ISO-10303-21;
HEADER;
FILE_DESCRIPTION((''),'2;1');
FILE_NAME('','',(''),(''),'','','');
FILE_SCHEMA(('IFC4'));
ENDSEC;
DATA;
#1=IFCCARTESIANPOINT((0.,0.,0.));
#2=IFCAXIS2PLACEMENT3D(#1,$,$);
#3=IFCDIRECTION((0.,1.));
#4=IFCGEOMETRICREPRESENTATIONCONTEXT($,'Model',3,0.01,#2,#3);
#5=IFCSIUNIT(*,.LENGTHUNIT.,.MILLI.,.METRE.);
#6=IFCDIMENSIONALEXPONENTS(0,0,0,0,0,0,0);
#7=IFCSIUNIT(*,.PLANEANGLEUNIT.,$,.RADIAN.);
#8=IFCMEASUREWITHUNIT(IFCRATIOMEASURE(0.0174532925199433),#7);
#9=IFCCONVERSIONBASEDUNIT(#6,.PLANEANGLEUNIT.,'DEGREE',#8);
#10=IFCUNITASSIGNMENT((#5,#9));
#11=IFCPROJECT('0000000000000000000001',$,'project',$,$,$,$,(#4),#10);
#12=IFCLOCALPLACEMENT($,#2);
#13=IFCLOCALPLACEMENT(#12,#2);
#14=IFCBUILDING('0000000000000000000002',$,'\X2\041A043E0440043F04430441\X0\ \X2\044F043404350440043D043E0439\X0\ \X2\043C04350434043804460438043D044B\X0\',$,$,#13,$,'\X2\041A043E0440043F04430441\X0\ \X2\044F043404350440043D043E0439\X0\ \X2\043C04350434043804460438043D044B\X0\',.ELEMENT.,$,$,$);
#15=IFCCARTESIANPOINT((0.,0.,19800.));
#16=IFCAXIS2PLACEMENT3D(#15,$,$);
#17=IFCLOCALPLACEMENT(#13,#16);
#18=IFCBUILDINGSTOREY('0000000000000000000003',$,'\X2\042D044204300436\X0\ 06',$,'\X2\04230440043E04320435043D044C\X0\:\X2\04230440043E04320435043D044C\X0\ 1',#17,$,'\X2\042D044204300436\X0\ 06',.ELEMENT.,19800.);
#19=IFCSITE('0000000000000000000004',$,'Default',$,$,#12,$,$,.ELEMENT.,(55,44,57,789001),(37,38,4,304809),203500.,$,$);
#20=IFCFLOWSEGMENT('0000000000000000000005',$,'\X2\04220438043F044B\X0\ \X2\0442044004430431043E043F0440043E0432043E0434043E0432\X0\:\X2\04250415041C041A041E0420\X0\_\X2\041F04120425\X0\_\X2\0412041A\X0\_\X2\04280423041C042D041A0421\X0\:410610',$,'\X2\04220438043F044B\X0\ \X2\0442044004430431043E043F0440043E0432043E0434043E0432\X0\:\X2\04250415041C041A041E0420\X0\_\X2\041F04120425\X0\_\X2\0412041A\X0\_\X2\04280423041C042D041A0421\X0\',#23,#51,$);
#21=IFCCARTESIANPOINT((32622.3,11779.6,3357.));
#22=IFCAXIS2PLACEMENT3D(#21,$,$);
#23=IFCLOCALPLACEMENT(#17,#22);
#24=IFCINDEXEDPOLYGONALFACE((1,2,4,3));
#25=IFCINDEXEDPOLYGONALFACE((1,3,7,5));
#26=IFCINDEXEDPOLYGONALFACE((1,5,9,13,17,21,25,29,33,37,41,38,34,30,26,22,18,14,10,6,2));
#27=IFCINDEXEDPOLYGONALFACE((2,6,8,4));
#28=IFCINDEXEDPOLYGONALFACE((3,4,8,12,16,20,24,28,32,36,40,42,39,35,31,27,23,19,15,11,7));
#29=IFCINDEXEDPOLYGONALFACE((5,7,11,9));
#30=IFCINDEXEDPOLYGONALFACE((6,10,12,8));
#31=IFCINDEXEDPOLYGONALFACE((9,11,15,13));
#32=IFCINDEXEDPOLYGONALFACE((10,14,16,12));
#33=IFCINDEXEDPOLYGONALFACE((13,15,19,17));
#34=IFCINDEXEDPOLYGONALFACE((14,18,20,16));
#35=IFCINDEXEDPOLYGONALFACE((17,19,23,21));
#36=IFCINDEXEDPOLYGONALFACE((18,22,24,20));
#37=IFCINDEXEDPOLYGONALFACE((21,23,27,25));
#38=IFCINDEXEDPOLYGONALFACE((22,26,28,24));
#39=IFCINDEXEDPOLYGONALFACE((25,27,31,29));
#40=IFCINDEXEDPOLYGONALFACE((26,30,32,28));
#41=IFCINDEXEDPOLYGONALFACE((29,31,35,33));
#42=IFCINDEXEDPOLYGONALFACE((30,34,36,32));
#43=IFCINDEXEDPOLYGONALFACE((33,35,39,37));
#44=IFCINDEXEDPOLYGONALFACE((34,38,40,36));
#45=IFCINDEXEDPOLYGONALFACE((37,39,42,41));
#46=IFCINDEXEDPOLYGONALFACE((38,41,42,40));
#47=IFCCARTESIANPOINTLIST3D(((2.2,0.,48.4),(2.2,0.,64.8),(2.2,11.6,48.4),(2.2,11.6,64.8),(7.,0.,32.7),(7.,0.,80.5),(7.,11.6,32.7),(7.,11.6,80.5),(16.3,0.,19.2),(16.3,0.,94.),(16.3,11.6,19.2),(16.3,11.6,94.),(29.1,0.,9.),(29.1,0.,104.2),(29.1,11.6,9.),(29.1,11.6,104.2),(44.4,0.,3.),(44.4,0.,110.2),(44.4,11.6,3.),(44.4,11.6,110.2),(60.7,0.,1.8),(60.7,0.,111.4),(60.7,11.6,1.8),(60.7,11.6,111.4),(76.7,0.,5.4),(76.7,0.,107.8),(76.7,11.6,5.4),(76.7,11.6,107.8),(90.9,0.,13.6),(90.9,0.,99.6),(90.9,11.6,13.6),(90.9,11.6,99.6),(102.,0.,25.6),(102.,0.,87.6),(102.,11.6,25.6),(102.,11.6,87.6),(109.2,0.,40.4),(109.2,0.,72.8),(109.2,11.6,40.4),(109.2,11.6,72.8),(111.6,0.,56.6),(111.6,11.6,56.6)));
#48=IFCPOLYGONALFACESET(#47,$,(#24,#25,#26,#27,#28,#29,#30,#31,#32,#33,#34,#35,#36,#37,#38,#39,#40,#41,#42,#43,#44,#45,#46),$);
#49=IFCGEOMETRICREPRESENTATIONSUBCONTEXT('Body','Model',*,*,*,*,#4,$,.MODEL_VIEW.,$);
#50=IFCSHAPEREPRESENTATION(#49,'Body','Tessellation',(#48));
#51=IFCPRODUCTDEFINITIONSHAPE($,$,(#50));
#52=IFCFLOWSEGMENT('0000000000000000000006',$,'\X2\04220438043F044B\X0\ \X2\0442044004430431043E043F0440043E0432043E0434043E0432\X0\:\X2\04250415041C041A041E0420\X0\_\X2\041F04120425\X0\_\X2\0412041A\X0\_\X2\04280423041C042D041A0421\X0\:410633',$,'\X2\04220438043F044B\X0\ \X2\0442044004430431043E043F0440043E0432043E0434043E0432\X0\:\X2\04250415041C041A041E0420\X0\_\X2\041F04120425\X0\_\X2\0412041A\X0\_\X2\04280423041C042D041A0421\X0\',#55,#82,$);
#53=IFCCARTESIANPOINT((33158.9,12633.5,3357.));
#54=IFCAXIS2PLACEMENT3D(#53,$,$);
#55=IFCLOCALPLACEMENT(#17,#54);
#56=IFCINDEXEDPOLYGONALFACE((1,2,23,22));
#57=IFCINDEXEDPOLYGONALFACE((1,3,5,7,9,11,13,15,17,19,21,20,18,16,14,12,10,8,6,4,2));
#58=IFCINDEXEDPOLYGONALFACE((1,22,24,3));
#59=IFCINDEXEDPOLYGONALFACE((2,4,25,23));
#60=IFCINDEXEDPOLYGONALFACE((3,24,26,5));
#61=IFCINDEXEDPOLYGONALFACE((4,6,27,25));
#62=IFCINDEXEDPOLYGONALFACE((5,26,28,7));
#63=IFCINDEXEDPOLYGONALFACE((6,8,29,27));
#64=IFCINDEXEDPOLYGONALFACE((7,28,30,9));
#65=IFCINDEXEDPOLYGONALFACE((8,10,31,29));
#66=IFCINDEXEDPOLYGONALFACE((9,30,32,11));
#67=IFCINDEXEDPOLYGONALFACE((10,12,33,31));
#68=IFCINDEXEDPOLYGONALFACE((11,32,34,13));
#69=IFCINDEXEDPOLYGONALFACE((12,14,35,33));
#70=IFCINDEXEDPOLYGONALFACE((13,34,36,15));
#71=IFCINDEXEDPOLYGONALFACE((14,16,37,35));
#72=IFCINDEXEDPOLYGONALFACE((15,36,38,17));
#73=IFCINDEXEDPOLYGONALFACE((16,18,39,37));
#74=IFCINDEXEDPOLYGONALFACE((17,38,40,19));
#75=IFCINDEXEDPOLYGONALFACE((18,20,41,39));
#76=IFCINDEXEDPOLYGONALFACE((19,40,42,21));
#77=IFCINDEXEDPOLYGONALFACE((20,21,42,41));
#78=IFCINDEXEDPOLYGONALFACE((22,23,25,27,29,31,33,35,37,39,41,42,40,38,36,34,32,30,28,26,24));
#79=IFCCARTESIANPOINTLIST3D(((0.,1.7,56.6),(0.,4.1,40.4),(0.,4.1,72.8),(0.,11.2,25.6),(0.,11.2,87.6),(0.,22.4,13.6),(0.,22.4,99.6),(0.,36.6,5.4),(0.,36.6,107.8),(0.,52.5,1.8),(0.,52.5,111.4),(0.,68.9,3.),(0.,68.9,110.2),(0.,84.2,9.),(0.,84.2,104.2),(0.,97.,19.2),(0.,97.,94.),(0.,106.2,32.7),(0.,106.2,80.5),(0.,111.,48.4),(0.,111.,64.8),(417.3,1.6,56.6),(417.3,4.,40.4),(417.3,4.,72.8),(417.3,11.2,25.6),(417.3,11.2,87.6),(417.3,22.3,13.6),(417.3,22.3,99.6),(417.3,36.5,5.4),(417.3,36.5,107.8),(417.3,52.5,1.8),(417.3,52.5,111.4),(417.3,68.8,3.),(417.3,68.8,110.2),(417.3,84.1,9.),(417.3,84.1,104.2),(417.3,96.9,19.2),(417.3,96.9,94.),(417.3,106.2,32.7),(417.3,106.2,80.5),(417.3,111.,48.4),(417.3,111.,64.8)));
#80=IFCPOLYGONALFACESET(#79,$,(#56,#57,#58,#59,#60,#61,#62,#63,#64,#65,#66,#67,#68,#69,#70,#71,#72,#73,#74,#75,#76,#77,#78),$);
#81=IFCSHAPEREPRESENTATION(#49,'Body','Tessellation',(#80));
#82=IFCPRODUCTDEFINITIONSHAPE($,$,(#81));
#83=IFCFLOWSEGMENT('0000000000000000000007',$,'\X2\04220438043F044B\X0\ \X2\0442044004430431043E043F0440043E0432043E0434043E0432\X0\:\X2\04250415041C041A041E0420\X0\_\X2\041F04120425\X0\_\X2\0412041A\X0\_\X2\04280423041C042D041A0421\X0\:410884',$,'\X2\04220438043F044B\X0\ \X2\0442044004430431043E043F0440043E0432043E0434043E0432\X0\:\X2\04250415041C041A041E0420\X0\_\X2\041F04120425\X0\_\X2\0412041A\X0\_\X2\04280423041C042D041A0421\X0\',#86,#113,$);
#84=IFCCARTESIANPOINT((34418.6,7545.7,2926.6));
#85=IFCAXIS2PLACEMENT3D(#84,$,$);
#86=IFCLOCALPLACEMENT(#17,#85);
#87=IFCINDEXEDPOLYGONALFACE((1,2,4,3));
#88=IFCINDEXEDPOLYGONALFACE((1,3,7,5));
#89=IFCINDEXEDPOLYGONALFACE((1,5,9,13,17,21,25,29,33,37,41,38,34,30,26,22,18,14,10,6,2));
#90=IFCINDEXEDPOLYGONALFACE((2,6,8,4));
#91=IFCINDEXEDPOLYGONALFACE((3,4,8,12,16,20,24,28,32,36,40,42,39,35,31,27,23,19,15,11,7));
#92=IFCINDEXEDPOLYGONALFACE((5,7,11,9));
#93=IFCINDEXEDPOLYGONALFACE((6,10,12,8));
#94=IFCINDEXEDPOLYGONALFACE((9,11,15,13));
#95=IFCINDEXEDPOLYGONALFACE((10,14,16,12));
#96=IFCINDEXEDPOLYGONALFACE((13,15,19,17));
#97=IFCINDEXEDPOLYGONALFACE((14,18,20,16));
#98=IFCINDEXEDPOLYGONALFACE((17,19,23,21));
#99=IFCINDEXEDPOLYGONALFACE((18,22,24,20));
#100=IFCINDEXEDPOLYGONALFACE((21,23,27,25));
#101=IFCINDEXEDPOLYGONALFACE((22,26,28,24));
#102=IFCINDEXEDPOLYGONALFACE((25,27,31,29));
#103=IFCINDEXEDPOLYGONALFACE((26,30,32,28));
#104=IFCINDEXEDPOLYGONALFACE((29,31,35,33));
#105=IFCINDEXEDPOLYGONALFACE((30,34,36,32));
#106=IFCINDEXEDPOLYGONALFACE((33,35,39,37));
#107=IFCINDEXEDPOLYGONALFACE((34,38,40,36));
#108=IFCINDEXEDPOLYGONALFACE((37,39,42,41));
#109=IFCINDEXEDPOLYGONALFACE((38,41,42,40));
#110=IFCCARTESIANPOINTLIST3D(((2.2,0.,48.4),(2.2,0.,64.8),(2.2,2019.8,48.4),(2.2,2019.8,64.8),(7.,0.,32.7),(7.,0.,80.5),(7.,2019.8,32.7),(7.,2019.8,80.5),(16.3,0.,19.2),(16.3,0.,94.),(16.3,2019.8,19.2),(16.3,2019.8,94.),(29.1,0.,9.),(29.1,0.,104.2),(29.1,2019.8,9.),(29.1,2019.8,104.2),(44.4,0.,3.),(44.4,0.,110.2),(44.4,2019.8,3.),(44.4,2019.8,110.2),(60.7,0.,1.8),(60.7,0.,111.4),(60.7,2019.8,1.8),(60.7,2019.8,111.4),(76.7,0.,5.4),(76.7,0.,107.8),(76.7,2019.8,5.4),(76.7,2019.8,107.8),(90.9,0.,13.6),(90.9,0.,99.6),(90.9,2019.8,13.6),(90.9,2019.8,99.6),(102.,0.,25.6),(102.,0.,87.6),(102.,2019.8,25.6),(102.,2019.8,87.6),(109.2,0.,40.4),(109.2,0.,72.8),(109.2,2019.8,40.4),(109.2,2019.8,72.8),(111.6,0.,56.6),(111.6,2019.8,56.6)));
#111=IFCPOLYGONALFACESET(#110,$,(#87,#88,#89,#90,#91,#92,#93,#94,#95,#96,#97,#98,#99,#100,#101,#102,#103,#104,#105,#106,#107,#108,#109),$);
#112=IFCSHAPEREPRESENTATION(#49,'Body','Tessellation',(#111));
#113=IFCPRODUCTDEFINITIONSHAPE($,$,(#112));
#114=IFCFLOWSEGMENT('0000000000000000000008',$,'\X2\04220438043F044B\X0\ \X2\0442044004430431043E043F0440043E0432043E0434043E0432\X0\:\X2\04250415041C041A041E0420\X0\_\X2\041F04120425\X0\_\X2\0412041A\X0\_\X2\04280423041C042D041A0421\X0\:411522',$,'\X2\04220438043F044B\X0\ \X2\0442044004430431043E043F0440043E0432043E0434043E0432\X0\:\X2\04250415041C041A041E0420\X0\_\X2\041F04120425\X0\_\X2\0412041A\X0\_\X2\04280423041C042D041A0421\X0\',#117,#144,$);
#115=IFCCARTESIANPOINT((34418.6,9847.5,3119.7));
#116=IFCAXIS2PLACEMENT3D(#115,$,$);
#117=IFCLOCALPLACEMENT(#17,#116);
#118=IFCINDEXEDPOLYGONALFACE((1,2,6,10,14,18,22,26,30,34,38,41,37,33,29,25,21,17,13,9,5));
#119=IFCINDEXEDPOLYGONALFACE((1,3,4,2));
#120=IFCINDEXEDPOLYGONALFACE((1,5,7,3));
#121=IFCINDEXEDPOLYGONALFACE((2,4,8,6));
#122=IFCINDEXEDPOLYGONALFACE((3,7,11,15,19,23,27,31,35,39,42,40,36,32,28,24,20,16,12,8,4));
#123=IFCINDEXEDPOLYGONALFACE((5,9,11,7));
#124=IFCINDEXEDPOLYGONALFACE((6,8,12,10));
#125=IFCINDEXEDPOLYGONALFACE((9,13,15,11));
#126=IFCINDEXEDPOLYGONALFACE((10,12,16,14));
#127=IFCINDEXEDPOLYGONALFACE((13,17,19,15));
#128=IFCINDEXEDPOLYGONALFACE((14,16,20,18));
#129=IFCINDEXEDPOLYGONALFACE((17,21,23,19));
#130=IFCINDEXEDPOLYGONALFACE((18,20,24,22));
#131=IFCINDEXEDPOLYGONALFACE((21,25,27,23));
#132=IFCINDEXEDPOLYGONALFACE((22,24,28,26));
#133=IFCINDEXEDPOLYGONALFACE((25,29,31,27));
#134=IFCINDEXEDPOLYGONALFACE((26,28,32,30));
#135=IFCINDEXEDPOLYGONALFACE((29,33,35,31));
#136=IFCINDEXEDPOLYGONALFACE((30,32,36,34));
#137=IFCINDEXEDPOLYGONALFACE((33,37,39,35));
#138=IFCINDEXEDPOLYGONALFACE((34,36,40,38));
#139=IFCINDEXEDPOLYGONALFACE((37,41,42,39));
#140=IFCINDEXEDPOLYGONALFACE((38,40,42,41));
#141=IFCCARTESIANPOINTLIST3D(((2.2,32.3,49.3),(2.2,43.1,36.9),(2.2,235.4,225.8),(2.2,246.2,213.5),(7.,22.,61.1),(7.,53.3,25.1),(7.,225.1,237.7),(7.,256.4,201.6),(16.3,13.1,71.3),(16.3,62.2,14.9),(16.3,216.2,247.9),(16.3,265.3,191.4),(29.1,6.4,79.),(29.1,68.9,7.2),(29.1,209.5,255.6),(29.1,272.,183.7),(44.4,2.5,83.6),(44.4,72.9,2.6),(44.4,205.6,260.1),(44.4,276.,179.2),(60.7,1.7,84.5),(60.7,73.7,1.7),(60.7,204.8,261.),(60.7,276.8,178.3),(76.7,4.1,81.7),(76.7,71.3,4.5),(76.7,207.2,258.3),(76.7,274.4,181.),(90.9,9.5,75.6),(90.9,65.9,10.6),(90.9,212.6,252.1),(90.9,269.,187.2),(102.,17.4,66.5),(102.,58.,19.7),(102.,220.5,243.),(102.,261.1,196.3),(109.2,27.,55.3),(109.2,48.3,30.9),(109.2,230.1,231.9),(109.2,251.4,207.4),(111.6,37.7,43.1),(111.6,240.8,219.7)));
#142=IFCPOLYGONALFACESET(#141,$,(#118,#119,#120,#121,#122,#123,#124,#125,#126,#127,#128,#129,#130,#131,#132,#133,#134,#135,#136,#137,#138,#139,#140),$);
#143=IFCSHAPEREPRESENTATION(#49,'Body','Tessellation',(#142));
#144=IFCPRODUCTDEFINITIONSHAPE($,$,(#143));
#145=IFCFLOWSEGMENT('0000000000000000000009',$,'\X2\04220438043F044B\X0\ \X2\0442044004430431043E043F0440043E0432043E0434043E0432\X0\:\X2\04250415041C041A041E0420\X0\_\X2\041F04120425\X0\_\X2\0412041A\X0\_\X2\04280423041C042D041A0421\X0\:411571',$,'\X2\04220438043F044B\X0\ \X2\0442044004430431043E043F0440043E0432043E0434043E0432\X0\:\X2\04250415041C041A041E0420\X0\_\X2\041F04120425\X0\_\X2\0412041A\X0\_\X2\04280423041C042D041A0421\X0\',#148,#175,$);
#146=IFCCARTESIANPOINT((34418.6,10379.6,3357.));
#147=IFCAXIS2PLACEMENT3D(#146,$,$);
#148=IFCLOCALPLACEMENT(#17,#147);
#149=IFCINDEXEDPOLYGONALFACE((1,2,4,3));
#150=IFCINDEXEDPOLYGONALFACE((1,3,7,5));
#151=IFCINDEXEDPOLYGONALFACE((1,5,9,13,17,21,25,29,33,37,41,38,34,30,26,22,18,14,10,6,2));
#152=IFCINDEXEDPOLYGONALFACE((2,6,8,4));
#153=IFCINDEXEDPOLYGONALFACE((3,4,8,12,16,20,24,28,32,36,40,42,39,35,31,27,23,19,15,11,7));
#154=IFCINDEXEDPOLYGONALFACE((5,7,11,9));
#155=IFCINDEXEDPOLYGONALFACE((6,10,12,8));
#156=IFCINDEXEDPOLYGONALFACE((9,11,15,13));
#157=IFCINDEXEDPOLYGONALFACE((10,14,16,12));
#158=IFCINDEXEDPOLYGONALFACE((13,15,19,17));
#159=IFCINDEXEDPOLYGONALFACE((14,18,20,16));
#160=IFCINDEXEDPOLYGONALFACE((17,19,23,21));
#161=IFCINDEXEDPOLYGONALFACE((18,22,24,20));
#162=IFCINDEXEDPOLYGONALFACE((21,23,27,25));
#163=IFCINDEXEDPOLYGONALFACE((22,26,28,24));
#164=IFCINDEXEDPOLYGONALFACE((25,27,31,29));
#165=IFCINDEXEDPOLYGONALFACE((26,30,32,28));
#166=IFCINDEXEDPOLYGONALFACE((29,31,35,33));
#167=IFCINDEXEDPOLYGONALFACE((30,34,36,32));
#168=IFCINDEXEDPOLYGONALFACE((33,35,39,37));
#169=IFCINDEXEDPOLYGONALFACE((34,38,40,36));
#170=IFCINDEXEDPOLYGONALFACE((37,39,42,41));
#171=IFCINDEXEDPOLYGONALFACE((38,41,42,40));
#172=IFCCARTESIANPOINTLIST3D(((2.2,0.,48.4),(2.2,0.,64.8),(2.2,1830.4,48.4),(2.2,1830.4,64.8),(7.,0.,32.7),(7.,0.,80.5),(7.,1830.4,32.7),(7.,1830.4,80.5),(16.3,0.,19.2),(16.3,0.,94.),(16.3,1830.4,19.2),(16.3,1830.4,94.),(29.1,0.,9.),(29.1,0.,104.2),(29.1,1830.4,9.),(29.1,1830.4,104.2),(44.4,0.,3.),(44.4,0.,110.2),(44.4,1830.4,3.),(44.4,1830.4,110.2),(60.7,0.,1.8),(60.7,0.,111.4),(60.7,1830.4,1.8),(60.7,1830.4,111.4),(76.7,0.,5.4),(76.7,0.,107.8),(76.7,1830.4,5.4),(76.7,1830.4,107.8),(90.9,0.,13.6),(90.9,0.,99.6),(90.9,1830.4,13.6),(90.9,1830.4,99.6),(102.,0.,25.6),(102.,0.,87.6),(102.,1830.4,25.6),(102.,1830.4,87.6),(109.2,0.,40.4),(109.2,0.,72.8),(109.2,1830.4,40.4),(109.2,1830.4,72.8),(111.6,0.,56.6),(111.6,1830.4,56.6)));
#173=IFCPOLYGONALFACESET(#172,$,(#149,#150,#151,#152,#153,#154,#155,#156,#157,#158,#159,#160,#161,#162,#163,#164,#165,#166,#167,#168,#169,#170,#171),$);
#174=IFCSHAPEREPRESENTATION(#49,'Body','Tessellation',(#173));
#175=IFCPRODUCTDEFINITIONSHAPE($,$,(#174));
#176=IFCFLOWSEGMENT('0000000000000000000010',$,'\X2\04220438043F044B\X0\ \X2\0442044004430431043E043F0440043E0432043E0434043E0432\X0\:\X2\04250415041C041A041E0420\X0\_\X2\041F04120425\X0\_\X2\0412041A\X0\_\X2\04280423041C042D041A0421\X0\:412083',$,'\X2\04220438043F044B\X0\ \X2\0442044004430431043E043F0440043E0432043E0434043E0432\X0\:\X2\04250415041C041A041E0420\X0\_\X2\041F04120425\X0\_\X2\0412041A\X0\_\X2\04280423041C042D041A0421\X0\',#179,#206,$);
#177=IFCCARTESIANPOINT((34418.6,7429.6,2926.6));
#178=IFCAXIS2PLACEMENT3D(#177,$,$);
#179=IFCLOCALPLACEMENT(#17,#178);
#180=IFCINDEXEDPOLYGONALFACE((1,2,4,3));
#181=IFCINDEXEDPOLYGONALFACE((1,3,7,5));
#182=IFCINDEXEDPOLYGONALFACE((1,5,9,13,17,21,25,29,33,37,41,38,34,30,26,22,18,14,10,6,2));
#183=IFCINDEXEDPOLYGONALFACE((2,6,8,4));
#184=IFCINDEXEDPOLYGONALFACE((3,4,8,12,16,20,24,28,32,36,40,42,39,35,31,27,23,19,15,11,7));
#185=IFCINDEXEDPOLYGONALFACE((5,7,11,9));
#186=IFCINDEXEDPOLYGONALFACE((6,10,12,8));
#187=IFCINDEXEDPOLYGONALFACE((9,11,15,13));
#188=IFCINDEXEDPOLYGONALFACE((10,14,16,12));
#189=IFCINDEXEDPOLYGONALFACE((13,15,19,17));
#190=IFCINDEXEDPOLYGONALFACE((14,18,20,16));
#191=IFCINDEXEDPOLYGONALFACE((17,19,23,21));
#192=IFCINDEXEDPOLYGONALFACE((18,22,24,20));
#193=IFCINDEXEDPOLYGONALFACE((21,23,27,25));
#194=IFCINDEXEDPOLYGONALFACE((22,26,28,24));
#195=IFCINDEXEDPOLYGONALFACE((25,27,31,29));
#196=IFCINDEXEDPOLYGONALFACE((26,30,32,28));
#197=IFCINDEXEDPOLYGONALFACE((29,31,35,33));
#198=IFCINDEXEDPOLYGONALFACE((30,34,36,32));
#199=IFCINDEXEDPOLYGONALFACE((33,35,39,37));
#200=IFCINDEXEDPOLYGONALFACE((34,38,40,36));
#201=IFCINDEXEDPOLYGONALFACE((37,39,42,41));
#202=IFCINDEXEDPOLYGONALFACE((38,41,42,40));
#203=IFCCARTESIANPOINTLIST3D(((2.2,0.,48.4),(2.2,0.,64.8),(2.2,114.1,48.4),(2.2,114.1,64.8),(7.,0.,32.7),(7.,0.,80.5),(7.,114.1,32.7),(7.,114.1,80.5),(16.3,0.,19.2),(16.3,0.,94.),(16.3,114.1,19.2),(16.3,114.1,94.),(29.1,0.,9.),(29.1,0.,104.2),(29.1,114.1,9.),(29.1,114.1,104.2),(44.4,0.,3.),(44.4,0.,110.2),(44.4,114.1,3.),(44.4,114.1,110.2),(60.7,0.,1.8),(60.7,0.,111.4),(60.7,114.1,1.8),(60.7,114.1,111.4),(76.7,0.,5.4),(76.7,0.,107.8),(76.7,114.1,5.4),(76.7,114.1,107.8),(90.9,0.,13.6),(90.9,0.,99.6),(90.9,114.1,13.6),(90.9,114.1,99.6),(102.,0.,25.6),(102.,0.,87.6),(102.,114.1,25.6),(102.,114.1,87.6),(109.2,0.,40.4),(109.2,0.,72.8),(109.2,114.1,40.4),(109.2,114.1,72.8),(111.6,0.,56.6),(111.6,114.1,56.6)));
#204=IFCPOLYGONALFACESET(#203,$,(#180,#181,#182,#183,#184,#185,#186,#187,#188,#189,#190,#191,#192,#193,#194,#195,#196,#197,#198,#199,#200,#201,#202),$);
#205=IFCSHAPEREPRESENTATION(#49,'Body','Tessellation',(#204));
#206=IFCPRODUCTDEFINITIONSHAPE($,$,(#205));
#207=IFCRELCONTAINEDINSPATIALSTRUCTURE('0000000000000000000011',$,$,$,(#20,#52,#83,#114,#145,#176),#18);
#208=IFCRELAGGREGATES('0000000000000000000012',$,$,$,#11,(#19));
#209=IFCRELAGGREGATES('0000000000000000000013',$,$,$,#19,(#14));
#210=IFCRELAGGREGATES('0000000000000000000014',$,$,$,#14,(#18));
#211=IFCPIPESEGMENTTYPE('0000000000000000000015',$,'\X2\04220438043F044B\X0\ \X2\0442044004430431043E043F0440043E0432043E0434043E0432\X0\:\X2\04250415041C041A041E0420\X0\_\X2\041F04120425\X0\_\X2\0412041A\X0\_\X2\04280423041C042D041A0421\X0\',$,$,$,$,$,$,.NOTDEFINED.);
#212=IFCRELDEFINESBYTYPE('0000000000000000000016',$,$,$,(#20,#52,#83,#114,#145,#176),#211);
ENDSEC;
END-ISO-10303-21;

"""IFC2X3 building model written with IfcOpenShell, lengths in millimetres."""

from ifc_helpers import new_model, entity, si_unit, converted_unit, direction, frame, origin, origin_2d_with_axis, place, context, subcontext, project, spatial, circle, extrude, type_object, element, save


model = new_model("IFC2X3")

# Units and contexts
model_context = context("Model", 3, precision=0.01, world=origin(), true_north=direction((0.0, 1.0)))
body_context = subcontext(model_context, "Body", "Model", "MODEL_VIEW")
ifc_project = project(units=[si_unit("LENGTHUNIT", "METRE", prefix="MILLI"), converted_unit("PLANEANGLEUNIT", "DEGREE", entity("IfcRatioMeasure", 0.0174532925199433), si_unit("PLANEANGLEUNIT", "RADIAN"), dimensions=[0, 0, 0, 0, 0, 0, 0])], contexts=[model_context])

# Site, building, storey
site_placement = place(None, origin())
site = spatial("IfcSite", under=ifc_project, at=site_placement, Name="Default", CompositionType="ELEMENT", RefLatitude=(55, 44, 57, 789001), RefLongitude=(37, 38, 4, 304809), RefElevation=203500.0)
building_placement = place(site_placement, origin())
building = spatial("IfcBuilding", under=site, at=building_placement, Name="Корпус ядерной медицины", LongName="Корпус ядерной медицины", CompositionType="ELEMENT")
storey_placement = place(building_placement, frame((0.0, 0.0, 19800.0)))
storey = spatial("IfcBuildingStorey", under=building, at=storey_placement, Name="Этаж 06", ObjectType="Уровень:Уровень 1", LongName="Этаж 06", CompositionType="ELEMENT", Elevation=19800.0)

# Flow segments
pipe_segment_type = type_object("IfcPipeSegmentType", Name="Типы трубопроводов:ХЕМКОР_ПВХ_ВК_ШУМЭКС", PredefinedType="NOTDEFINED")
flow_segment_1_placement = place(storey_placement, frame((32622.3, 11779.6, 3357.0)))
element("IfcFlowSegment", 1, at=flow_segment_1_placement, inside=storey, type_object=pipe_segment_type, Name="Типы трубопроводов:ХЕМКОР_ПВХ_ВК_ШУМЭКС:410610", ObjectType="Типы трубопроводов:ХЕМКОР_ПВХ_ВК_ШУМЭКС", context=body_context, shape_type="SweptSolid", body=[
    extrude(circle(Radius=55.0, at=origin_2d_with_axis()), frame((56.6, 0.0, 56.6), z_axis=(0.0, 1.0, 0.0), x_axis=(1.0, 0.0, 0.0)), (0.0, 0.0, 1.0), 11.6),
])
flow_segment_2_placement = place(storey_placement, frame((33158.9, 12633.5, 3357.0)))
element("IfcFlowSegment", 2, at=flow_segment_2_placement, inside=storey, type_object=pipe_segment_type, Name="Типы трубопроводов:ХЕМКОР_ПВХ_ВК_ШУМЭКС:410633", ObjectType="Типы трубопроводов:ХЕМКОР_ПВХ_ВК_ШУМЭКС", context=body_context, shape_type="SweptSolid", body=[
    extrude(circle(Radius=55.0, at=origin_2d_with_axis()), frame((0.0, 56.7, 56.6), z_axis=(1.0, -0.000147, 0.0), x_axis=(-0.000147, -1.0, 0.0)), (0.0, 0.0, 1.0), 417.3),
])
flow_segment_3_placement = place(storey_placement, frame((34418.6, 7545.7, 2926.6)))
element("IfcFlowSegment", 3, at=flow_segment_3_placement, inside=storey, type_object=pipe_segment_type, Name="Типы трубопроводов:ХЕМКОР_ПВХ_ВК_ШУМЭКС:410884", ObjectType="Типы трубопроводов:ХЕМКОР_ПВХ_ВК_ШУМЭКС", context=body_context, shape_type="SweptSolid", body=[
    extrude(circle(Radius=55.0, at=origin_2d_with_axis()), frame((56.6, 0.0, 56.6), z_axis=(0.0, 1.0, 0.0), x_axis=(1.0, 0.0, 0.0)), (0.0, 0.0, 1.0), 2019.8),
])
flow_segment_4_placement = place(storey_placement, frame((34418.6, 9847.5, 3119.7)))
element("IfcFlowSegment", 4, at=flow_segment_4_placement, inside=storey, type_object=pipe_segment_type, Name="Типы трубопроводов:ХЕМКОР_ПВХ_ВК_ШУМЭКС:411522", ObjectType="Типы трубопроводов:ХЕМКОР_ПВХ_ВК_ШУМЭКС", context=body_context, shape_type="SweptSolid", body=[
    extrude(circle(Radius=55.0, at=origin_2d_with_axis()), frame((56.6, 37.7, 43.1), z_axis=(0.0, 0.75471, 0.656059), x_axis=(1.0, 0.0, 0.0)), (0.0, 0.0, 1.0), 269.1),
])
flow_segment_5_placement = place(storey_placement, frame((34418.6, 10379.6, 3357.0)))
element("IfcFlowSegment", 5, at=flow_segment_5_placement, inside=storey, type_object=pipe_segment_type, Name="Типы трубопроводов:ХЕМКОР_ПВХ_ВК_ШУМЭКС:411571", ObjectType="Типы трубопроводов:ХЕМКОР_ПВХ_ВК_ШУМЭКС", context=body_context, shape_type="SweptSolid", body=[
    extrude(circle(Radius=55.0, at=origin_2d_with_axis()), frame((56.6, 0.0, 56.6), z_axis=(0.0, 1.0, 0.0), x_axis=(1.0, 0.0, 0.0)), (0.0, 0.0, 1.0), 1830.4),
])
flow_segment_6_placement = place(storey_placement, frame((34418.6, 7429.6, 2926.6)))
element("IfcFlowSegment", 6, at=flow_segment_6_placement, inside=storey, type_object=pipe_segment_type, Name="Типы трубопроводов:ХЕМКОР_ПВХ_ВК_ШУМЭКС:412083", ObjectType="Типы трубопроводов:ХЕМКОР_ПВХ_ВК_ШУМЭКС", context=body_context, shape_type="SweptSolid", body=[
    extrude(circle(Radius=55.0, at=origin_2d_with_axis()), frame((56.6, 0.0, 56.6), z_axis=(0.0, 1.0, 0.0), x_axis=(1.0, 0.0, 0.0)), (0.0, 0.0, 1.0), 114.1),
])

save(model, "model.ifc")
